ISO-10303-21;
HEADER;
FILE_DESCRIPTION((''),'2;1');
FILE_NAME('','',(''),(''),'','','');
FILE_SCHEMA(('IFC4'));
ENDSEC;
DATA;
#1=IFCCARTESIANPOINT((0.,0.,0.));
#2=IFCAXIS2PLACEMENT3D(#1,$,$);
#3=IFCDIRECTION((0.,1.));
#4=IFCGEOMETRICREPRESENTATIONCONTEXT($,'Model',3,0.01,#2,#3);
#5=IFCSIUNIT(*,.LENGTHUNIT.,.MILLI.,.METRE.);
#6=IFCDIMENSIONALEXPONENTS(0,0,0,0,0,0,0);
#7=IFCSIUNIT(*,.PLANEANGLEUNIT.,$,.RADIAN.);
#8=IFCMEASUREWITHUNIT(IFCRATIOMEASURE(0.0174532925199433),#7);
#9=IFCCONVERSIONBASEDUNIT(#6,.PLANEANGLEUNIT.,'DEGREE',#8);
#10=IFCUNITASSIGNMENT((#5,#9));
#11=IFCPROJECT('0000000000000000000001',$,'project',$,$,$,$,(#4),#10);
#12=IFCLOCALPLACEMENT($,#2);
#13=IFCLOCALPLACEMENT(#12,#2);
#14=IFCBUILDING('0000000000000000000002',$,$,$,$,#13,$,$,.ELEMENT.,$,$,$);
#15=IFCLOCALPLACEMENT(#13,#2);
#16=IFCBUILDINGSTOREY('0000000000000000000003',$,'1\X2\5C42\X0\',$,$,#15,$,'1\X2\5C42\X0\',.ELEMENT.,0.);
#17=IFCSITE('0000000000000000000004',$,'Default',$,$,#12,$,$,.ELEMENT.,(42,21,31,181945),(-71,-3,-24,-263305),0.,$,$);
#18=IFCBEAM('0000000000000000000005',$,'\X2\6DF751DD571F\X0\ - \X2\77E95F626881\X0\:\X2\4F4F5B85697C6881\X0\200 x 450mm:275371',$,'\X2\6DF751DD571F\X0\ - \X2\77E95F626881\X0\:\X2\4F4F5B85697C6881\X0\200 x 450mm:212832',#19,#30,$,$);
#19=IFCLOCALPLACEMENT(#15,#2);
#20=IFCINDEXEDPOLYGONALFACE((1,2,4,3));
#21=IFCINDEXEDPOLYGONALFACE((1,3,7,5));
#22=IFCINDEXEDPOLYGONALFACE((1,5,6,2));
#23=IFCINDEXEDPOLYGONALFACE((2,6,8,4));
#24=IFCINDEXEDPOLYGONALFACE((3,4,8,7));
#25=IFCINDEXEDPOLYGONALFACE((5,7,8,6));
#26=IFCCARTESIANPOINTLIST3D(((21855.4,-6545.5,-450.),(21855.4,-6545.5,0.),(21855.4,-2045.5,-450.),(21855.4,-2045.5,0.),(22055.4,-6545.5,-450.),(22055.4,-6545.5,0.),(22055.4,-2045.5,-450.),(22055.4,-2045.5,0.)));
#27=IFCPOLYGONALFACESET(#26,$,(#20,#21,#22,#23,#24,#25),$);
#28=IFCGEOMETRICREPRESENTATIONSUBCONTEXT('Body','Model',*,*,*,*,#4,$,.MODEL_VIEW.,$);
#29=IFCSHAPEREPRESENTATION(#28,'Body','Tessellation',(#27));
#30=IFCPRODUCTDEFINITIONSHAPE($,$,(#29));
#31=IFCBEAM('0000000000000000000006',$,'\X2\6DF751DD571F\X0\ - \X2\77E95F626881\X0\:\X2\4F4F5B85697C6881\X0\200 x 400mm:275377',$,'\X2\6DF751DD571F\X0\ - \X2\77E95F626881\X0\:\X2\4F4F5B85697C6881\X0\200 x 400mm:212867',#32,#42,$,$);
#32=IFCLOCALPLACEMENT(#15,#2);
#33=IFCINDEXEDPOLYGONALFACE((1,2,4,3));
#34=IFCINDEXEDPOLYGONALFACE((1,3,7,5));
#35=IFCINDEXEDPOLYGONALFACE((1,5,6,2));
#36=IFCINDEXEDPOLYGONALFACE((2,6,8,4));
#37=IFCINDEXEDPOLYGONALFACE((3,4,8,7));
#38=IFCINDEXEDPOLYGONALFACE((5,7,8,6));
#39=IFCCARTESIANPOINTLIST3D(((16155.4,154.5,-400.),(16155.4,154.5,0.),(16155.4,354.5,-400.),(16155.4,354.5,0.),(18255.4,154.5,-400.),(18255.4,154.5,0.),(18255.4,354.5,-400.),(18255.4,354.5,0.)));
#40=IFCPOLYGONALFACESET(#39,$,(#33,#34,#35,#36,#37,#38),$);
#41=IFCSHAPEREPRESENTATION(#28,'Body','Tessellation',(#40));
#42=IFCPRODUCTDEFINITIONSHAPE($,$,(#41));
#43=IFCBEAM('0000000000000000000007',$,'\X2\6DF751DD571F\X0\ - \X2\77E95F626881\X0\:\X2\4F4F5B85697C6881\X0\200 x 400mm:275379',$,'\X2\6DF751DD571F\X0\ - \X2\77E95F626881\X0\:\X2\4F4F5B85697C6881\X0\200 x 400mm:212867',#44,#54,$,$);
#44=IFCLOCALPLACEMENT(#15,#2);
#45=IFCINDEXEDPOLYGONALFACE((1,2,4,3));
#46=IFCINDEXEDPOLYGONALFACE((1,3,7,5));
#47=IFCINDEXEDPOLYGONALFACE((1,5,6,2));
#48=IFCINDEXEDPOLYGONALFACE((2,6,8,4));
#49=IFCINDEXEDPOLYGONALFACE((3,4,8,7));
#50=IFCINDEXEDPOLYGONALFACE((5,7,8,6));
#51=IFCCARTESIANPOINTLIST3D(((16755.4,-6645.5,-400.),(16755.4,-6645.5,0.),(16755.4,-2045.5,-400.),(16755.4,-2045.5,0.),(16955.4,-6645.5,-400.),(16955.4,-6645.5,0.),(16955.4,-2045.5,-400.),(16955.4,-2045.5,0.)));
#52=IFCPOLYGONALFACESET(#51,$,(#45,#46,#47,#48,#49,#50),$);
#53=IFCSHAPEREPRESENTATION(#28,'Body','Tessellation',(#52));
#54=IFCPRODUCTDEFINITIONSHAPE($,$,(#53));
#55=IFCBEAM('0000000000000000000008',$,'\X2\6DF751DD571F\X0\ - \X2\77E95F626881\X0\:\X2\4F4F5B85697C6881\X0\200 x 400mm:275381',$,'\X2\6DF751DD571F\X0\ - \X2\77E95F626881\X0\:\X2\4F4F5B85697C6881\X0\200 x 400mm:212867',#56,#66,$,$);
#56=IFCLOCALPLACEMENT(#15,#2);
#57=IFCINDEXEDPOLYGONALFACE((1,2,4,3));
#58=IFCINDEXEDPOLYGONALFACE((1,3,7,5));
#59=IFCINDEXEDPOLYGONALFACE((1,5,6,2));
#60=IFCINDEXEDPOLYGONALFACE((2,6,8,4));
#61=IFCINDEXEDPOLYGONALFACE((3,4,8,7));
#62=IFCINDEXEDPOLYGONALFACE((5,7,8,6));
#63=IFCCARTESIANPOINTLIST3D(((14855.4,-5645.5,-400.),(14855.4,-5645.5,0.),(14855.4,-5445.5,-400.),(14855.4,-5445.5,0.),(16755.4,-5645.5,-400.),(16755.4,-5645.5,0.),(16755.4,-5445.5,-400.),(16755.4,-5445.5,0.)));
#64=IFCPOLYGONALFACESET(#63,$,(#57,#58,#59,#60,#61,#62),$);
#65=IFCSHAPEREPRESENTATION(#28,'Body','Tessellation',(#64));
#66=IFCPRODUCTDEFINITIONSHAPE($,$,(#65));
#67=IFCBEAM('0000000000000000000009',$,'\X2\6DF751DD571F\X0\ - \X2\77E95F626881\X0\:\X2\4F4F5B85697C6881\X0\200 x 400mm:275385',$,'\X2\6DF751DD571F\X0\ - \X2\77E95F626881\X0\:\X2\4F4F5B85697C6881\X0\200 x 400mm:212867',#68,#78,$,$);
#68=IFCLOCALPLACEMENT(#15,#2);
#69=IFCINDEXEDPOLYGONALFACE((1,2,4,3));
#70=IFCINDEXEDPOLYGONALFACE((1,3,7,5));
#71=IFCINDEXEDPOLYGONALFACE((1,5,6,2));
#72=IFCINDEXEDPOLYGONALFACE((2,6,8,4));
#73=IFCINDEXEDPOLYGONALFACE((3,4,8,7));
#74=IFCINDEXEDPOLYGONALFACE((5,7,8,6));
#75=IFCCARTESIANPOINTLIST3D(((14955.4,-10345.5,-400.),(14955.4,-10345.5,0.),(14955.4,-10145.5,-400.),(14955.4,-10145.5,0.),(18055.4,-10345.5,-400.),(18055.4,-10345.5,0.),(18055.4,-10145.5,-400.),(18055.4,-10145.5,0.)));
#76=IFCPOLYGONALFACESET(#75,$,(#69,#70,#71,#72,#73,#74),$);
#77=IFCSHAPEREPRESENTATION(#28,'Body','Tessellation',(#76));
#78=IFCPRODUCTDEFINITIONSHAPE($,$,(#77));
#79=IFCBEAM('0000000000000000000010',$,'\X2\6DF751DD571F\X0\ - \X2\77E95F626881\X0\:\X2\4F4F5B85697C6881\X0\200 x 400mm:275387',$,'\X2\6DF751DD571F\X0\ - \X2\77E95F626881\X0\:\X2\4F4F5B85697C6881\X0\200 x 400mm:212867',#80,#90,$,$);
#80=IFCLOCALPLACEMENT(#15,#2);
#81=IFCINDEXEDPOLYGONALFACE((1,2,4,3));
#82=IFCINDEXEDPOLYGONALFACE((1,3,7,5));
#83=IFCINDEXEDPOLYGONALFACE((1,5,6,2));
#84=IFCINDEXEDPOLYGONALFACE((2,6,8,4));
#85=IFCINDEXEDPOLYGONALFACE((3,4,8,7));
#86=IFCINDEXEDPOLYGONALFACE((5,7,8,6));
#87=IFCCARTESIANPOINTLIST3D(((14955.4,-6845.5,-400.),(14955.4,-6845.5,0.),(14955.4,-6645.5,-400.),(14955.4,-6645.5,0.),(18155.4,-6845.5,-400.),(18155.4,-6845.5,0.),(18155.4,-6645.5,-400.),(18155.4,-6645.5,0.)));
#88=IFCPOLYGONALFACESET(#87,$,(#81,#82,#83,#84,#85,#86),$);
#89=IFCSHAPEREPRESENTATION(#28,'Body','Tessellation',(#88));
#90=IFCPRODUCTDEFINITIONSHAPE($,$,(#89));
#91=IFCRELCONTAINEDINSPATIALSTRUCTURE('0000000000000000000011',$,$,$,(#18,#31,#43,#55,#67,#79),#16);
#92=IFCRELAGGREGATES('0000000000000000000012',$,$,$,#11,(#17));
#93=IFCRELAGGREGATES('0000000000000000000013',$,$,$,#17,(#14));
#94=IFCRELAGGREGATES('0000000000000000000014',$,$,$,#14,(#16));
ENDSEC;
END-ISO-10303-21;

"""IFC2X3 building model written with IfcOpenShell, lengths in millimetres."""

from ifc_helpers import new_model, entity, si_unit, converted_unit, direction, frame, frame_2d, origin, place, context, subcontext, project, spatial, rectangle, extrude, element, save


model = new_model("IFC2X3")

# Units and contexts
model_context = context("Model", 3, precision=0.01, world=origin(), true_north=direction((0.0, 1.0)))
body_context = subcontext(model_context, "Body", "Model", "MODEL_VIEW")
ifc_project = project(units=[si_unit("LENGTHUNIT", "METRE", prefix="MILLI"), converted_unit("PLANEANGLEUNIT", "DEGREE", entity("IfcRatioMeasure", 0.0174532925199433), si_unit("PLANEANGLEUNIT", "RADIAN"), dimensions=[0, 0, 0, 0, 0, 0, 0])], contexts=[model_context])

# Site, building, storey
site_placement = place(None, origin())
site = spatial("IfcSite", under=ifc_project, at=site_placement, Name="Default", CompositionType="ELEMENT", RefLatitude=(42, 21, 31, 181945), RefLongitude=(-71, -3, -24, -263305), RefElevation=0.0)
building_placement = place(site_placement, origin())
building = spatial("IfcBuilding", under=site, at=building_placement, CompositionType="ELEMENT")
storey_placement = place(building_placement, origin())
storey = spatial("IfcBuildingStorey", under=building, at=storey_placement, Name="1层", LongName="1层", CompositionType="ELEMENT", Elevation=0.0)

# Beams
beam_1_placement = place(storey_placement, frame((21955.4, -1945.5, 0.0), z_axis=(0.0, 0.0, 1.0), x_axis=(0.0, -1.0, 0.0)))
element("IfcBeam", 1, at=beam_1_placement, inside=storey, Name="混凝土 - 矩形梁:住宅楼梁200 x 450mm:275371", ObjectType="混凝土 - 矩形梁:住宅楼梁200 x 450mm:212832", context=body_context, shape_type="SweptSolid", body=[
    extrude(rectangle(XDim=450.0, YDim=200.0, at=frame_2d((0.0, 0.0), x_axis=(1.0, 0.0))), frame((100.0, 0.0, -225.0), z_axis=(1.0, 0.0, 0.0), x_axis=(0.0, 0.0, -1.0)), (0.0, 0.0, 1.0), 4500.0),
])
beam_2_placement = place(storey_placement, frame((18355.4, 254.5, 0.0), z_axis=(0.0, 0.0, 1.0), x_axis=(-1.0, 0.0, 0.0)))
element("IfcBeam", 2, at=beam_2_placement, inside=storey, Name="混凝土 - 矩形梁:住宅楼梁200 x 400mm:275377", ObjectType="混凝土 - 矩形梁:住宅楼梁200 x 400mm:212867", context=body_context, shape_type="SweptSolid", body=[
    extrude(rectangle(XDim=400.0, YDim=200.0, at=frame_2d((0.0, 0.0), x_axis=(1.0, 0.0))), frame((100.0, 0.0, -200.0), z_axis=(1.0, 0.0, 0.0), x_axis=(0.0, 0.0, -1.0)), (0.0, 0.0, 1.0), 2100.0),
])
beam_3_placement = place(storey_placement, frame((16855.4, -1945.5, 0.0), z_axis=(0.0, 0.0, 1.0), x_axis=(0.0, -1.0, 0.0)))
element("IfcBeam", 3, at=beam_3_placement, inside=storey, Name="混凝土 - 矩形梁:住宅楼梁200 x 400mm:275379", ObjectType="混凝土 - 矩形梁:住宅楼梁200 x 400mm:212867", context=body_context, shape_type="SweptSolid", body=[
    extrude(rectangle(XDim=400.0, YDim=200.0, at=frame_2d((0.0, 0.0), x_axis=(1.0, 0.0))), frame((100.0, 0.0, -200.0), z_axis=(1.0, 0.0, 0.0), x_axis=(0.0, 0.0, -1.0)), (0.0, 0.0, 1.0), 4600.0),
])
beam_4_placement = place(storey_placement, frame((16855.4, -5545.5, 0.0), z_axis=(0.0, 0.0, 1.0), x_axis=(-1.0, 0.0, 0.0)))
element("IfcBeam", 4, at=beam_4_placement, inside=storey, Name="混凝土 - 矩形梁:住宅楼梁200 x 400mm:275381", ObjectType="混凝土 - 矩形梁:住宅楼梁200 x 400mm:212867", context=body_context, shape_type="SweptSolid", body=[
    extrude(rectangle(XDim=400.0, YDim=200.0, at=frame_2d((0.0, 0.0), x_axis=(1.0, 0.0))), frame((100.0, 0.0, -200.0), z_axis=(1.0, 0.0, 0.0), x_axis=(0.0, 0.0, -1.0)), (0.0, 0.0, 1.0), 1900.0),
])
beam_5_placement = place(storey_placement, frame((18055.4, -10245.5, 0.0), z_axis=(0.0, 0.0, 1.0), x_axis=(-1.0, 0.0, 0.0)))
element("IfcBeam", 5, at=beam_5_placement, inside=storey, Name="混凝土 - 矩形梁:住宅楼梁200 x 400mm:275385", ObjectType="混凝土 - 矩形梁:住宅楼梁200 x 400mm:212867", context=body_context, shape_type="SweptSolid", body=[
    extrude(rectangle(XDim=400.0, YDim=200.0, at=frame_2d((0.0, 0.0), x_axis=(1.0, 0.0))), frame((0.0, 0.0, -200.0), z_axis=(1.0, 0.0, 0.0), x_axis=(0.0, 0.0, -1.0)), (0.0, 0.0, 1.0), 3100.0),
])
beam_6_placement = place(storey_placement, frame((18355.4, -6745.5, 0.0), z_axis=(0.0, 0.0, 1.0), x_axis=(-1.0, 0.0, 0.0)))
element("IfcBeam", 6, at=beam_6_placement, inside=storey, Name="混凝土 - 矩形梁:住宅楼梁200 x 400mm:275387", ObjectType="混凝土 - 矩形梁:住宅楼梁200 x 400mm:212867", context=body_context, shape_type="SweptSolid", body=[
    extrude(rectangle(XDim=400.0, YDim=200.0, at=frame_2d((0.0, 0.0), x_axis=(1.0, 0.0))), frame((200.0, 0.0, -200.0), z_axis=(1.0, 0.0, 0.0), x_axis=(0.0, 0.0, -1.0)), (0.0, 0.0, 1.0), 3200.0),
])

save(model, "model.ifc")
